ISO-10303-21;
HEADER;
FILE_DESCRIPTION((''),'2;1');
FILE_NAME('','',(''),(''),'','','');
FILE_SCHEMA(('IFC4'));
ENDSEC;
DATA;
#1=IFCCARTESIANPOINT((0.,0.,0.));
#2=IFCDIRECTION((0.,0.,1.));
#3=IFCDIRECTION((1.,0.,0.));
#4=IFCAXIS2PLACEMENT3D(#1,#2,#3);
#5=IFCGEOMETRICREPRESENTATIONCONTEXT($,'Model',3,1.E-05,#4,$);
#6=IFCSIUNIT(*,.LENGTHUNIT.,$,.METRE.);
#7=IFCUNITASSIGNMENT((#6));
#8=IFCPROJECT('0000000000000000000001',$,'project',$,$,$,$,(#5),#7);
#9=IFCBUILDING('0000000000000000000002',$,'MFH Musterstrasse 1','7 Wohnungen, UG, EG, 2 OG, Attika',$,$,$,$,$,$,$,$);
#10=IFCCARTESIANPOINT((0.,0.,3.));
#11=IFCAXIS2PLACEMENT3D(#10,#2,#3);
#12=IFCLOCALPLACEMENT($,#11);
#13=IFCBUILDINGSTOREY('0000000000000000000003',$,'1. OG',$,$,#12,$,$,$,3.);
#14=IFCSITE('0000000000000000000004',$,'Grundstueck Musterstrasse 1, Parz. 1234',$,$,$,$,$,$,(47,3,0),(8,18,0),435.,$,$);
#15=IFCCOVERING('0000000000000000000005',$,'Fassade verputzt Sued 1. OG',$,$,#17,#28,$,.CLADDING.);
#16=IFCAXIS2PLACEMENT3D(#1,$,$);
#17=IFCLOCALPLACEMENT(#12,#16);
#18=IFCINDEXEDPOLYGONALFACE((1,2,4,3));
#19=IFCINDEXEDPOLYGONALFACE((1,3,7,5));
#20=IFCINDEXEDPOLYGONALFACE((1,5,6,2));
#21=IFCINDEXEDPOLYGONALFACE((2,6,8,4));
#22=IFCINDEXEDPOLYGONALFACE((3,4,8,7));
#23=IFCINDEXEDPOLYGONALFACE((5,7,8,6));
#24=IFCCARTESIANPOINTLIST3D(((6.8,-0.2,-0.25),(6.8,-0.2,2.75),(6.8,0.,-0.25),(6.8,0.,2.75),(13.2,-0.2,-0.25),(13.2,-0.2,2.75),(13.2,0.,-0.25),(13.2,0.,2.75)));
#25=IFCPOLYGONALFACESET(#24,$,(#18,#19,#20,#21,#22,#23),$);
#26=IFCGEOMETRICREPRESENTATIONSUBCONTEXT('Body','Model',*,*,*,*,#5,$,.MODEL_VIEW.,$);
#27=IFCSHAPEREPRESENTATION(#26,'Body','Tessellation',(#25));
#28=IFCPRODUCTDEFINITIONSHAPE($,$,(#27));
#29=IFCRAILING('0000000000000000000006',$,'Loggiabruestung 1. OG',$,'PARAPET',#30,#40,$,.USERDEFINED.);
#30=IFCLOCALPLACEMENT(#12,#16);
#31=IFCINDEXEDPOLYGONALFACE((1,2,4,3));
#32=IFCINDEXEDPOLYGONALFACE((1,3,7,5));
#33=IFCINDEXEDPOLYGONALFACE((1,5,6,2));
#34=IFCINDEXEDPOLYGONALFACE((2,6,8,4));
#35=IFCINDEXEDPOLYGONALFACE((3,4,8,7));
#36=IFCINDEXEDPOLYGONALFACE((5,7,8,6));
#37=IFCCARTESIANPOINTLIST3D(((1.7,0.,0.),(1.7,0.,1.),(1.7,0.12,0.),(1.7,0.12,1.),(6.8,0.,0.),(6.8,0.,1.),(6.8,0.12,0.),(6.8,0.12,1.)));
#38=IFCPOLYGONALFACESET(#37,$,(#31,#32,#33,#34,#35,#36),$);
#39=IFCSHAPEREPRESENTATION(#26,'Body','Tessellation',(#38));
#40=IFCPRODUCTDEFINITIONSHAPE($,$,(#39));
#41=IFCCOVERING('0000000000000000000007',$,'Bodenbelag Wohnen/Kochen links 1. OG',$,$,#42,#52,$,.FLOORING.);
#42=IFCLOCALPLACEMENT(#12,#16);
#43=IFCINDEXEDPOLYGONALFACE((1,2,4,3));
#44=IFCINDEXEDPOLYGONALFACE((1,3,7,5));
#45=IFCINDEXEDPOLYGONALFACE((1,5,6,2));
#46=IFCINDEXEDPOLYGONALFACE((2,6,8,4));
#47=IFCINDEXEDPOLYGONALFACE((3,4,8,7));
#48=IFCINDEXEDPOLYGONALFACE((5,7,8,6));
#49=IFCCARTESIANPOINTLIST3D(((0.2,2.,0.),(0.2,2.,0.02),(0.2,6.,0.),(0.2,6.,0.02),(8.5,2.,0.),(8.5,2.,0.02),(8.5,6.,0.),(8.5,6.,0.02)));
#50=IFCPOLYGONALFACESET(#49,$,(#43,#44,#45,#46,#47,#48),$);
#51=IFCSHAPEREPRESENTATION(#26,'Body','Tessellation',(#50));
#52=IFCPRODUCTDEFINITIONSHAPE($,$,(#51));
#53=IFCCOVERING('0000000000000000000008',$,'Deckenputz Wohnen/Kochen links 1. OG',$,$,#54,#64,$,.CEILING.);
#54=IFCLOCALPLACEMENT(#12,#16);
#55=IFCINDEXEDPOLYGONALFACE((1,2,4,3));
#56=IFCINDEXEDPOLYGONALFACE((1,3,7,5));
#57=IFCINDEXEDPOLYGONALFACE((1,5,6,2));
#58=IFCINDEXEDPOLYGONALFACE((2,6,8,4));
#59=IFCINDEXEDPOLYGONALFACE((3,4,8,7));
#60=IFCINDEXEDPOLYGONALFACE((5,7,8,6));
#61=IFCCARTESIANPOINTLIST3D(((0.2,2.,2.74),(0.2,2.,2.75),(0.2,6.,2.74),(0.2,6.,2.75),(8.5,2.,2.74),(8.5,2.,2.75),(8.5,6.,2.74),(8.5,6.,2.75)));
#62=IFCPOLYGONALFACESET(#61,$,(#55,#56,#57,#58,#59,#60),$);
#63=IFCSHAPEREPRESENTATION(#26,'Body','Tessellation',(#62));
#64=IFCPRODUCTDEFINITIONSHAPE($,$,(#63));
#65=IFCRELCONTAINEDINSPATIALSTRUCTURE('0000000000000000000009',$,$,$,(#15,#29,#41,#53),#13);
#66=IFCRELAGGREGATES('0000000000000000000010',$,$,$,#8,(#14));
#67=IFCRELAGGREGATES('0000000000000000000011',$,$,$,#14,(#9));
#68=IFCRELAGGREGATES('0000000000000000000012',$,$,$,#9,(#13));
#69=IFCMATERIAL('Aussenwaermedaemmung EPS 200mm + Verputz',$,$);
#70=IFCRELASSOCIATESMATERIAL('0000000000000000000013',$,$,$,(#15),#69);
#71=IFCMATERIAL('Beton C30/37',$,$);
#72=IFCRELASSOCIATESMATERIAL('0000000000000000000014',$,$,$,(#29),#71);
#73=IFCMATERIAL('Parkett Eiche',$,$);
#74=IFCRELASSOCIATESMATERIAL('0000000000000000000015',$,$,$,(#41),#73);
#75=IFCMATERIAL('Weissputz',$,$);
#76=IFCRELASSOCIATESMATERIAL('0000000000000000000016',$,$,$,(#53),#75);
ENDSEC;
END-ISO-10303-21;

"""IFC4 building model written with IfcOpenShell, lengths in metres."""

from ifc_helpers import new_model, si_unit, frame, frame_2d, origin_with_axes, place, context, subcontext, project, spatial, rectangle, extrude, material, element, save


model = new_model("IFC4")

# Units and contexts
model_context = context("Model", 3, precision=1e-05, world=origin_with_axes())
body_context = subcontext(model_context, "Body", "Model", "MODEL_VIEW")
ifc_project = project(units=[si_unit("LENGTHUNIT", "METRE")], contexts=[model_context])

# Site, building, storey
site = spatial("IfcSite", under=ifc_project, Name="Grundstueck Musterstrasse 1, Parz. 1234", RefLatitude=(47, 3, 0), RefLongitude=(8, 18, 0), RefElevation=435.0)
building = spatial("IfcBuilding", under=site, Name="MFH Musterstrasse 1", Description="7 Wohnungen, UG, EG, 2 OG, Attika")
storey_placement = place(None, frame((0.0, 0.0, 3.0), z_axis=(0.0, 0.0, 1.0), x_axis=(1.0, 0.0, 0.0)))
storey = spatial("IfcBuildingStorey", under=building, at=storey_placement, Name="1. OG", Elevation=3.0)

# Shared definitions
ifc_material_1 = material(Name="Aussenwaermedaemmung EPS 200mm + Verputz")

# Covering
covering_1_placement = place(storey_placement, frame((7.0, -0.2, -0.25), z_axis=(0.0, 0.0, 1.0), x_axis=(1.0, 0.0, 0.0)))
element("IfcCovering", 1, at=covering_1_placement, inside=storey, material=ifc_material_1, Name="Fassade verputzt Sued 1. OG", PredefinedType="CLADDING", context=body_context, shape_type="SweptSolid", body=[
    extrude(rectangle(XDim=6.4, YDim=0.2, at=frame_2d((3.0, 0.1))), origin_with_axes(), (0.0, 0.0, 1.0), 3.0),
])

# Railing
ifc_material_2 = material(Name="Beton C30/37")
railing_placement = place(storey_placement, frame((1.7, 0.0, 0.0), z_axis=(0.0, 0.0, 1.0), x_axis=(1.0, 0.0, 0.0)))
element("IfcRailing", 2, at=railing_placement, inside=storey, material=ifc_material_2, Name="Loggiabruestung 1. OG", ObjectType="PARAPET", PredefinedType="USERDEFINED", context=body_context, shape_type="SweptSolid", body=[
    extrude(rectangle(XDim=5.1, YDim=0.12, at=frame_2d((2.55, 0.06))), origin_with_axes(), (0.0, 0.0, 1.0), 1.0),
])

# Coverings
ifc_material_3 = material(Name="Parkett Eiche")
covering_2_placement = place(storey_placement, frame((0.2, 2.0, 0.0), z_axis=(0.0, 0.0, 1.0), x_axis=(1.0, 0.0, 0.0)))
element("IfcCovering", 3, at=covering_2_placement, inside=storey, material=ifc_material_3, Name="Bodenbelag Wohnen/Kochen links 1. OG", PredefinedType="FLOORING", context=body_context, shape_type="SweptSolid", body=[
    extrude(rectangle(XDim=8.3, YDim=4.0, at=frame_2d((4.15, 2.0))), origin_with_axes(), (0.0, 0.0, 1.0), 0.02),
])
ifc_material_4 = material(Name="Weissputz")
covering_3_placement = place(storey_placement, frame((0.2, 2.0, 2.74), z_axis=(0.0, 0.0, 1.0), x_axis=(1.0, 0.0, 0.0)))
element("IfcCovering", 4, at=covering_3_placement, inside=storey, material=ifc_material_4, Name="Deckenputz Wohnen/Kochen links 1. OG", PredefinedType="CEILING", context=body_context, shape_type="SweptSolid", body=[
    extrude(rectangle(XDim=8.3, YDim=4.0, at=frame_2d((4.15, 2.0))), origin_with_axes(), (0.0, 0.0, 1.0), 0.01),
])

save(model, "model.ifc")
